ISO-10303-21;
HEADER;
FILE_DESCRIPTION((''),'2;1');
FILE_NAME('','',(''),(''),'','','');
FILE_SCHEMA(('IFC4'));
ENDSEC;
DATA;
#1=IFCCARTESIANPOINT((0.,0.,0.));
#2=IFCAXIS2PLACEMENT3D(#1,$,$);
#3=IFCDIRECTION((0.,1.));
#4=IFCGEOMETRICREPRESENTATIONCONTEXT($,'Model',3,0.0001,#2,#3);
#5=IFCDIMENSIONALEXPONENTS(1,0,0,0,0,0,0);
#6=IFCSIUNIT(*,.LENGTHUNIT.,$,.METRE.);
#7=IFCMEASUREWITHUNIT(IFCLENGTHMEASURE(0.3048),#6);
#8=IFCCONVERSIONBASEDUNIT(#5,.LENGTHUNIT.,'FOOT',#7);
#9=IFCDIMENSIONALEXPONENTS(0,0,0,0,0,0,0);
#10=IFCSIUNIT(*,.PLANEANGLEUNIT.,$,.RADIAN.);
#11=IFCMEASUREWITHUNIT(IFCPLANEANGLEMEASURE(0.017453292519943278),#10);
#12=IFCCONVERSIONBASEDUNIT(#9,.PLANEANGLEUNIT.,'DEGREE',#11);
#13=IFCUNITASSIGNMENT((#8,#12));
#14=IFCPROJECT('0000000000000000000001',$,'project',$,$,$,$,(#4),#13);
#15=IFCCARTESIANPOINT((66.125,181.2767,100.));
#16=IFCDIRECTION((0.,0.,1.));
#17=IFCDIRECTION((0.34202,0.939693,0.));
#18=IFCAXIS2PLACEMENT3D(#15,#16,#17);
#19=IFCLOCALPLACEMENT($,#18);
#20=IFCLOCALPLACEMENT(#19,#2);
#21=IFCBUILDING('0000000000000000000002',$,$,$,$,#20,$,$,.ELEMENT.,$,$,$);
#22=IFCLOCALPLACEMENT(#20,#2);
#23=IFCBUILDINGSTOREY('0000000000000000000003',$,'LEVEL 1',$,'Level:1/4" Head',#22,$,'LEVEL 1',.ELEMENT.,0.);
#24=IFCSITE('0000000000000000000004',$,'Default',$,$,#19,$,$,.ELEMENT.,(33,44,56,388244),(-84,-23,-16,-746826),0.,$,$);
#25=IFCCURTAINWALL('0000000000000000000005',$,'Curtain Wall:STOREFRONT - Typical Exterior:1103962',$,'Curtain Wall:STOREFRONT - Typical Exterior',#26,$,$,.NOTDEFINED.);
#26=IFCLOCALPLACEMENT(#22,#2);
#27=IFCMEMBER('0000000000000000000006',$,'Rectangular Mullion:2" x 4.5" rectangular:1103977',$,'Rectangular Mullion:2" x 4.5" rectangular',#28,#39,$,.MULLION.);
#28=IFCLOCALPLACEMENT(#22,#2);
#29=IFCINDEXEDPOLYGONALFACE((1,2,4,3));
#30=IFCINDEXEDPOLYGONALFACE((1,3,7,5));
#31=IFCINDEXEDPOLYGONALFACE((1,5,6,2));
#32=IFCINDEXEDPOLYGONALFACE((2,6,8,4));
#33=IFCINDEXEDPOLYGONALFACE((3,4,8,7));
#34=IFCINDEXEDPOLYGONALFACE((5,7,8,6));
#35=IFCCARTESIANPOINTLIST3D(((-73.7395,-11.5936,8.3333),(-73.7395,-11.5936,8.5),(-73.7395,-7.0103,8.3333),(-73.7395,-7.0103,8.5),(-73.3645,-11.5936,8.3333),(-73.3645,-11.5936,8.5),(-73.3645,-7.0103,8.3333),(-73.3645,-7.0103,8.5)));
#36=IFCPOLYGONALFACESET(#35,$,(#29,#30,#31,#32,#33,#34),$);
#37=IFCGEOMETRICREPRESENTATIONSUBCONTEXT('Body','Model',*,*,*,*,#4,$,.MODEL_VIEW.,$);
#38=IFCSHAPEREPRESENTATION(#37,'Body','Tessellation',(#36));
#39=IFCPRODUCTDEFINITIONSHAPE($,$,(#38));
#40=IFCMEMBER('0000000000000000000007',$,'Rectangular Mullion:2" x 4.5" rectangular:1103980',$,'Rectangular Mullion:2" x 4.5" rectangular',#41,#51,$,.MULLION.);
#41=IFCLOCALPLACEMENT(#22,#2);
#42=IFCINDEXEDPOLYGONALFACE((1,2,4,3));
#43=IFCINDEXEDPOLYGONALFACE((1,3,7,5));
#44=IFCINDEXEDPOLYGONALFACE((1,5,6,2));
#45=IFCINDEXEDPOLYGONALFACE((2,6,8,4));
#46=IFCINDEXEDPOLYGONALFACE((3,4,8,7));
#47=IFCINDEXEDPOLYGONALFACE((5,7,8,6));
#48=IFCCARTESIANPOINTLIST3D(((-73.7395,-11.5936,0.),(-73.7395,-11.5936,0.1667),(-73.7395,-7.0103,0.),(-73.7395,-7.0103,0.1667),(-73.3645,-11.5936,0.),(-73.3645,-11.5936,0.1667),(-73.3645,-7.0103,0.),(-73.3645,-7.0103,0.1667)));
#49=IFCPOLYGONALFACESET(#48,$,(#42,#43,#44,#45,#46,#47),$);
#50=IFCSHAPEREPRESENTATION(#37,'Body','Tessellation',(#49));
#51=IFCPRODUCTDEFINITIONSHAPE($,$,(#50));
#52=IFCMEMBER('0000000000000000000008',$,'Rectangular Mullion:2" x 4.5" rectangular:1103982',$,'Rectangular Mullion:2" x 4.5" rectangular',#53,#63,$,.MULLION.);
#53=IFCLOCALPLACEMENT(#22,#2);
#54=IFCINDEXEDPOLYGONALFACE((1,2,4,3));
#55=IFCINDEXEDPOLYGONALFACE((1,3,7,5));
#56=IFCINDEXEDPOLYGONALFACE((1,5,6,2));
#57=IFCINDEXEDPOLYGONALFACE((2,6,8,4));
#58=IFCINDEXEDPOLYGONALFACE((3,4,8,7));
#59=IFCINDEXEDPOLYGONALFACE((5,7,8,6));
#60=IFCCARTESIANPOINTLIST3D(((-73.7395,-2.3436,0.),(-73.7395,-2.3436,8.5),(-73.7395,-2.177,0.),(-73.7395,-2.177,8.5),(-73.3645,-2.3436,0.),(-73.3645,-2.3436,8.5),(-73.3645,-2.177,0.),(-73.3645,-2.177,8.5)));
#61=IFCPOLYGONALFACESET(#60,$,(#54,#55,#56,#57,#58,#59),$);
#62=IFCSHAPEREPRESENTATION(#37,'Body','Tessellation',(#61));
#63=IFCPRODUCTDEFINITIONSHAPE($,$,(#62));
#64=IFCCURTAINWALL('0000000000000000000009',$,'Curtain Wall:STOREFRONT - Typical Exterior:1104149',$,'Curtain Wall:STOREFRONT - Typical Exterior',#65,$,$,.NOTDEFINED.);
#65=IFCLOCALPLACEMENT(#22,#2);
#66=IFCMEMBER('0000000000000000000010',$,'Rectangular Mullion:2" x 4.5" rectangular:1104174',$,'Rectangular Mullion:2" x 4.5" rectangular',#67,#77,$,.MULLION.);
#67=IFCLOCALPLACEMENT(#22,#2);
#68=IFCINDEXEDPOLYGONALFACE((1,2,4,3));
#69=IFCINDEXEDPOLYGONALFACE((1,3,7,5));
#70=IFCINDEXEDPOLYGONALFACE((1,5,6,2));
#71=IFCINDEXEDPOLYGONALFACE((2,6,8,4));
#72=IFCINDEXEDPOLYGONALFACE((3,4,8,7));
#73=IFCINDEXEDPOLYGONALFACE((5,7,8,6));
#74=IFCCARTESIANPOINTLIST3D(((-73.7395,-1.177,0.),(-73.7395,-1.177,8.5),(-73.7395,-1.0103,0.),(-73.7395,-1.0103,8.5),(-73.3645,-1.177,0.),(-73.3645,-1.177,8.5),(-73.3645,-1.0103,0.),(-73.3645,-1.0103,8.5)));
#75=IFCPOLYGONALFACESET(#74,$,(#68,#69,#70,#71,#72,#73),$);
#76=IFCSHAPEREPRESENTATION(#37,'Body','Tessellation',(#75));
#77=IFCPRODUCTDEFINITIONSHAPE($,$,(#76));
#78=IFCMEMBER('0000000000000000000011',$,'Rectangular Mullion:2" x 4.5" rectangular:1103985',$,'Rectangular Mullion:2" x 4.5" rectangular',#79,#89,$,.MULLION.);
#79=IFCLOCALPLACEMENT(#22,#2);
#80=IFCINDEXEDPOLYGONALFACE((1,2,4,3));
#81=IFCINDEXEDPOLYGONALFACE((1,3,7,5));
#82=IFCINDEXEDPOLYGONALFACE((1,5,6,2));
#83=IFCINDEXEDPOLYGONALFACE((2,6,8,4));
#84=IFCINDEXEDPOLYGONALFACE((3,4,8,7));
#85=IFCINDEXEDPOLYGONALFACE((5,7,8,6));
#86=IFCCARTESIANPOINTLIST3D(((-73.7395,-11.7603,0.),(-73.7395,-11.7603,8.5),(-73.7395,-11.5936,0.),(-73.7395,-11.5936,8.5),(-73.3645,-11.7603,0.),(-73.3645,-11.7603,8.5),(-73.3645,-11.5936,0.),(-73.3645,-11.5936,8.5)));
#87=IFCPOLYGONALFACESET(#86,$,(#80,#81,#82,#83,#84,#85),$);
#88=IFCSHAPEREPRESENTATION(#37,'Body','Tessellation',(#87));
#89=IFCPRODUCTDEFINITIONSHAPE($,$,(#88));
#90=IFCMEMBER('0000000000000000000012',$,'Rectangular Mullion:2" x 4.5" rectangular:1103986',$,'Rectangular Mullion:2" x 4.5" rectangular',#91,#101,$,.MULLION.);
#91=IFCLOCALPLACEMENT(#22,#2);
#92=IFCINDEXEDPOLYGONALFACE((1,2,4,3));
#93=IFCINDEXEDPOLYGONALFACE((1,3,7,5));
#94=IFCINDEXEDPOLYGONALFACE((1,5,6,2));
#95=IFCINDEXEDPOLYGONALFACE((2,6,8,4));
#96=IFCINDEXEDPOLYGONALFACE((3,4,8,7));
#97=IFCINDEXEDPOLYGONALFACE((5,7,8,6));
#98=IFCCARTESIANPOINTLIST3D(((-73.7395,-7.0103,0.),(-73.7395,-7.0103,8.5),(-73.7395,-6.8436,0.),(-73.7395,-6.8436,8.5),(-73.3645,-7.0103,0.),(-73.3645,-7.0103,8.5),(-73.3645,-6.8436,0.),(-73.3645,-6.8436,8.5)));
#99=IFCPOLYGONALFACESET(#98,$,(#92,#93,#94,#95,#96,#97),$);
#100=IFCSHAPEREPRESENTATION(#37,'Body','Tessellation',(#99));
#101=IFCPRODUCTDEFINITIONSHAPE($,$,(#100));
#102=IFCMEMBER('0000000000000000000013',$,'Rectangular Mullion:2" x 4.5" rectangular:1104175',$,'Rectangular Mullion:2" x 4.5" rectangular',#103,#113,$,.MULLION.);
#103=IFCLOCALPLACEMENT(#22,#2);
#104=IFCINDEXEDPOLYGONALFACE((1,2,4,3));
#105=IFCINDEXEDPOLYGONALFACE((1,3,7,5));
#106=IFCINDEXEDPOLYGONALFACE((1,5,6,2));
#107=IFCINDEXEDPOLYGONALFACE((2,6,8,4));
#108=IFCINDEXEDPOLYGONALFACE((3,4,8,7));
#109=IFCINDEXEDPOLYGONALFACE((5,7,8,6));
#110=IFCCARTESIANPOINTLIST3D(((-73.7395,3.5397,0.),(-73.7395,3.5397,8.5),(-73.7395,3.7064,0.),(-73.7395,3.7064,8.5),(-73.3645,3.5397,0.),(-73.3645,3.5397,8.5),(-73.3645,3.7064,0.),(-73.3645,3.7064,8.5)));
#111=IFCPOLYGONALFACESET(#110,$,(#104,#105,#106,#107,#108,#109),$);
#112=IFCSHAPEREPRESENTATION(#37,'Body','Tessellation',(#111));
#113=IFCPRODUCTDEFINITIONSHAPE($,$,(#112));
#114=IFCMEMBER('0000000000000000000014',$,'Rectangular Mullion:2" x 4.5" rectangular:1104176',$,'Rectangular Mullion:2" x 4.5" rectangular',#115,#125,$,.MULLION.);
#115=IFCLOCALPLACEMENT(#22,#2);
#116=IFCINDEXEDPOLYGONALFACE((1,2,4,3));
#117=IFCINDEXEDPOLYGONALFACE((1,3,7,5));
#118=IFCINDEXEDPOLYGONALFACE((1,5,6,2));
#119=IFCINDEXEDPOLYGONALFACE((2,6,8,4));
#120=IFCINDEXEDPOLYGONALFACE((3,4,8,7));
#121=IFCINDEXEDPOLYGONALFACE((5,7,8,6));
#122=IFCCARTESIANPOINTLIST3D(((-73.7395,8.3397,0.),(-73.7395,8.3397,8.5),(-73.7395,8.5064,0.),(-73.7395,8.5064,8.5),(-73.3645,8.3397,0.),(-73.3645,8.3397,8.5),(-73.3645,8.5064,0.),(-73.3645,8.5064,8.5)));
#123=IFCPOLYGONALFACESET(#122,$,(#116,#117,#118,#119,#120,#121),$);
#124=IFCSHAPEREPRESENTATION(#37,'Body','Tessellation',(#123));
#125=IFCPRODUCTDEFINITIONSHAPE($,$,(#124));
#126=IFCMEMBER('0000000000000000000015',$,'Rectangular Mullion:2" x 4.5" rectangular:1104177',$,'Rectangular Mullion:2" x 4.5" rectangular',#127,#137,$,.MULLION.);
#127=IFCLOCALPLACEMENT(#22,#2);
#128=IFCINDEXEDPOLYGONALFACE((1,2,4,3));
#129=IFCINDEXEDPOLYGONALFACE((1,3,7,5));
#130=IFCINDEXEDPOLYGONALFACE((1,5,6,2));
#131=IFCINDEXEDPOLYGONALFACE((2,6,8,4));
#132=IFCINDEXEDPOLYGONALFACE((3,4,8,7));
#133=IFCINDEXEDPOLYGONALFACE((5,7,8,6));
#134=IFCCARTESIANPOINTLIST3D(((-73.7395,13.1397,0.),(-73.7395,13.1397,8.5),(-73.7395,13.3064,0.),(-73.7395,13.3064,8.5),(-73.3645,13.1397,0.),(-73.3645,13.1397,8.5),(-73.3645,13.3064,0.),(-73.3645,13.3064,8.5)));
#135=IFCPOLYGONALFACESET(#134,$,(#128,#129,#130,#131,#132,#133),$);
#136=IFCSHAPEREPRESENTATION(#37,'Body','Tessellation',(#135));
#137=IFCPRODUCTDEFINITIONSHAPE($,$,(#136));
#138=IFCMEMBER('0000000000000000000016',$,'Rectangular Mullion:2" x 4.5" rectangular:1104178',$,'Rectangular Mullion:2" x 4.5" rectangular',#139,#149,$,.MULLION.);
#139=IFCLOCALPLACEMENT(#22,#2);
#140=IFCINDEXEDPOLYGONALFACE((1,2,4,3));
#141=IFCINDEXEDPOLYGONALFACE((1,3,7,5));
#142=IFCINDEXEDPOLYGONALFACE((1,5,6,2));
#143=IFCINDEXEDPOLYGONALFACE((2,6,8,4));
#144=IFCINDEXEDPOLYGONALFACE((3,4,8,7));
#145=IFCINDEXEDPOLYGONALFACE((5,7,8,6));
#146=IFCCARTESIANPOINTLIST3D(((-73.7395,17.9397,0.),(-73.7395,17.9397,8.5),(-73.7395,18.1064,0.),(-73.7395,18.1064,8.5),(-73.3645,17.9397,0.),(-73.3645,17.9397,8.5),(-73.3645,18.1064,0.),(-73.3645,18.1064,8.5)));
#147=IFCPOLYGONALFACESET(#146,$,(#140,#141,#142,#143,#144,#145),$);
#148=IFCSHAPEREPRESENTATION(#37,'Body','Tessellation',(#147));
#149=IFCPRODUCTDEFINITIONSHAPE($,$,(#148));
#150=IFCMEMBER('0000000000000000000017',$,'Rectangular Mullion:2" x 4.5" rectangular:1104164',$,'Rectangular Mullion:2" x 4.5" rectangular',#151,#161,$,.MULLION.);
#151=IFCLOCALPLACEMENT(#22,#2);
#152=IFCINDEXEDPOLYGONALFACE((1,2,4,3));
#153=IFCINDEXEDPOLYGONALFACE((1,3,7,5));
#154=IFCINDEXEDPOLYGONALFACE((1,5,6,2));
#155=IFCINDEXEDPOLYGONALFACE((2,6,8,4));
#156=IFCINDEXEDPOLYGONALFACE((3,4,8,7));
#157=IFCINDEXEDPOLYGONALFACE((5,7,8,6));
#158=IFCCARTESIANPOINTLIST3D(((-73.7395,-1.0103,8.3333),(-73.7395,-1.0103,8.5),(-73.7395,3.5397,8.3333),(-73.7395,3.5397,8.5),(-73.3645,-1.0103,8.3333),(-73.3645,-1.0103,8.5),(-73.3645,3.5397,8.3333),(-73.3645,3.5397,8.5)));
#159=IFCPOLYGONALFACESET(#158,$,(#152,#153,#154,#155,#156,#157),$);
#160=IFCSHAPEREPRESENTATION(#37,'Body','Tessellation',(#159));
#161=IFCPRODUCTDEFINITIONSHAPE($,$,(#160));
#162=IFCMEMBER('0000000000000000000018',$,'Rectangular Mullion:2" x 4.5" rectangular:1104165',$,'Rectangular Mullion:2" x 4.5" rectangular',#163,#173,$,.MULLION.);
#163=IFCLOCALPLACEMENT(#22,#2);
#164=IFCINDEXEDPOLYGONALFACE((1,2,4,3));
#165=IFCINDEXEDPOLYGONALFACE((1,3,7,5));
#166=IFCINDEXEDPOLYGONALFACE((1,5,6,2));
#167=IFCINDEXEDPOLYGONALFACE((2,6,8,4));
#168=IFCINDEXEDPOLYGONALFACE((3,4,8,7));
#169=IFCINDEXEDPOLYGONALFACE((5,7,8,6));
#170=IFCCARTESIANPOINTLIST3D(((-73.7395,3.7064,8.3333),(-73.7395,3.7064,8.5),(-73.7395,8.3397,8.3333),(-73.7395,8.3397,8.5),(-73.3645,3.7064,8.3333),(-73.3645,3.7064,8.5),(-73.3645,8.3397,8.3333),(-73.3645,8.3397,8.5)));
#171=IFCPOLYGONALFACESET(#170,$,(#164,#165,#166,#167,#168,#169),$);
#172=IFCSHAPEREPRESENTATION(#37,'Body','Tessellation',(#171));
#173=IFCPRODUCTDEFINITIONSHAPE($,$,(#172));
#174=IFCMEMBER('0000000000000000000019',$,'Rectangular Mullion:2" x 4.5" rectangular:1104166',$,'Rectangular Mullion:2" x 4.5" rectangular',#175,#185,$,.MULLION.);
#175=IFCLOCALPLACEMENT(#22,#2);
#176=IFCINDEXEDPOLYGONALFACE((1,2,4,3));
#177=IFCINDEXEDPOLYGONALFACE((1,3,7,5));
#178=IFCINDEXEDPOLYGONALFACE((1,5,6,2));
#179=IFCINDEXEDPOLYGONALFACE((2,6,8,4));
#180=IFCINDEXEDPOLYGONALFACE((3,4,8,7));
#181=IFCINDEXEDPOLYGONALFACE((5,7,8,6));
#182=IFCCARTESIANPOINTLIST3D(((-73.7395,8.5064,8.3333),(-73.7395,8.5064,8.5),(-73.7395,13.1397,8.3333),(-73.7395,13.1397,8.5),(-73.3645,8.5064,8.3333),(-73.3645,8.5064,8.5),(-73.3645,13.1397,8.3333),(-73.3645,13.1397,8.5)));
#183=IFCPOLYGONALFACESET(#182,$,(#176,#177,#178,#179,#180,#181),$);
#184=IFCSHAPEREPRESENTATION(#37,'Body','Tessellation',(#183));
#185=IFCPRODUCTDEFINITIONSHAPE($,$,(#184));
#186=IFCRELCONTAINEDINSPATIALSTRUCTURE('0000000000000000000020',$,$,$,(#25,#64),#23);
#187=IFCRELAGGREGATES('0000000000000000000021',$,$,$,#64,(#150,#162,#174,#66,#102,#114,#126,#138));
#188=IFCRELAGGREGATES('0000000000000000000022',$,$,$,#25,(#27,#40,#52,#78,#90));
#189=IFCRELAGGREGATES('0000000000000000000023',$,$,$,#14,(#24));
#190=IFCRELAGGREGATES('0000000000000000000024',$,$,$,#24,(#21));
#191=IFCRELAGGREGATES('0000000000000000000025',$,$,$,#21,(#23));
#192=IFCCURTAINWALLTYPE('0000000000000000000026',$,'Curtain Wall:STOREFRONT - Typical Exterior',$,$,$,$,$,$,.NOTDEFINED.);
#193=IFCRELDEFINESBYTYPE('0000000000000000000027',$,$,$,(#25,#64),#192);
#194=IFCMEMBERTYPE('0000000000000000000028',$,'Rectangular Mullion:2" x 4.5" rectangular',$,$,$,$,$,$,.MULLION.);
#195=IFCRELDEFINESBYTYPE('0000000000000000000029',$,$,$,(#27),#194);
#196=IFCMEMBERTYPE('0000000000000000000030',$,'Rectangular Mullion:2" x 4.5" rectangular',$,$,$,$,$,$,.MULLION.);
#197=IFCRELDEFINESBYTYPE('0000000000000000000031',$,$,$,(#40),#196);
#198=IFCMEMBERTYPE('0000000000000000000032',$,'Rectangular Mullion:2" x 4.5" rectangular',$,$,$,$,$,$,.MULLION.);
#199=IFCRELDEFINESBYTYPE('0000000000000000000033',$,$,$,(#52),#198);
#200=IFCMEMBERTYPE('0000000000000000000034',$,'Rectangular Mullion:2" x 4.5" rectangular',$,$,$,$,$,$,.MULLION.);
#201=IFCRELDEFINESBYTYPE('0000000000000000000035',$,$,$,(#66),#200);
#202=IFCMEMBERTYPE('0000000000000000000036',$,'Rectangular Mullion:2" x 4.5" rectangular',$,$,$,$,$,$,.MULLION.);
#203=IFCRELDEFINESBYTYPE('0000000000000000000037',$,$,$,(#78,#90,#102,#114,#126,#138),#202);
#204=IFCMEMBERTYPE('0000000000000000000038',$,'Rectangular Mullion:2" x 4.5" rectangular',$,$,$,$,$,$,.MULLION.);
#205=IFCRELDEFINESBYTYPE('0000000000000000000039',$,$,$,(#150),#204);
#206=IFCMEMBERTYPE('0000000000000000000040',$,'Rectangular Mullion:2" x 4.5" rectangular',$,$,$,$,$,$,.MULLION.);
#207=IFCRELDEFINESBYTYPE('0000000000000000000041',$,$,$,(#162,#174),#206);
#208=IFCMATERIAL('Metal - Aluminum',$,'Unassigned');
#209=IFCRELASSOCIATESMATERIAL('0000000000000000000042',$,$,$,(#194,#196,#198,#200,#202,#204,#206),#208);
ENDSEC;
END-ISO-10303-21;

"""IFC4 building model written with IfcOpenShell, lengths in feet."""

from ifc_helpers import new_model, entity, si_unit, converted_unit, direction, frame, origin, origin_2d_with_axis, place, context, subcontext, project, spatial, rectangle, extrude, source, transform, mapped, material, material_profile, profile_set, type_object, type_shapes, element, aggregate, save


model = new_model("IFC4")

# Units and contexts
model_context = context("Model", 3, precision=0.0001, world=origin(), true_north=direction((0.0, 1.0)))
body_context = subcontext(model_context, "Body", "Model", "MODEL_VIEW")
ifc_project = project(units=[converted_unit("LENGTHUNIT", "FOOT", entity("IfcLengthMeasure", 0.3048), si_unit("LENGTHUNIT", "METRE"), dimensions=[1, 0, 0, 0, 0, 0, 0]), converted_unit("PLANEANGLEUNIT", "DEGREE", entity("IfcPlaneAngleMeasure", 0.017453292519943278), si_unit("PLANEANGLEUNIT", "RADIAN"), dimensions=[0, 0, 0, 0, 0, 0, 0])], contexts=[model_context])

# Site, building, storey
site_placement = place(None, frame((66.125, 181.2767, 100.0), z_axis=(0.0, 0.0, 1.0), x_axis=(0.34202, 0.939693, 0.0)))
site = spatial("IfcSite", under=ifc_project, at=site_placement, Name="Default", CompositionType="ELEMENT", RefLatitude=(33, 44, 56, 388244), RefLongitude=(-84, -23, -16, -746826), RefElevation=0.0)
building_placement = place(site_placement, origin())
building = spatial("IfcBuilding", under=site, at=building_placement, CompositionType="ELEMENT")
storey_placement = place(building_placement, origin())
storey = spatial("IfcBuildingStorey", under=building, at=storey_placement, Name="LEVEL 1", ObjectType="Level:1/4\" Head", LongName="LEVEL 1", CompositionType="ELEMENT", Elevation=0.0)

# Curtain wall, members
curtain_wall_type = type_object("IfcCurtainWallType", Name="Curtain Wall:STOREFRONT - Typical Exterior", PredefinedType="NOTDEFINED")
curtain_wall_1_placement = place(storey_placement, origin())
curtain_wall_1 = element("IfcCurtainWall", 1, at=curtain_wall_1_placement, inside=storey, type_object=curtain_wall_type, Name="Curtain Wall:STOREFRONT - Typical Exterior:1103962", ObjectType="Curtain Wall:STOREFRONT - Typical Exterior", PredefinedType="NOTDEFINED")
ifc_material_1 = material(Name="Metal - Aluminum", Category="Unassigned")
ifc_material_profile = material_profile(ifc_material_1, rectangle(XDim=0.1667, YDim=0.375, at=origin_2d_with_axis()), Name="2\" x 4.5\" rectangular")
ifc_profile_set = profile_set([ifc_material_profile], Name="2\" x 4.5\" rectangular")
member_type_1 = type_object("IfcMemberType", Name="Rectangular Mullion:2\" x 4.5\" rectangular", PredefinedType="MULLION", material=ifc_profile_set)
shared_shape_1 = source(origin(), body_context, "Body", "SweptSolid", [
    extrude(rectangle(XDim=0.1667, YDim=0.375, at=origin_2d_with_axis()), frame((-0.0833, 0.0, -4.5833), z_axis=(0.0, 0.0, 1.0), x_axis=(-1.0, 0.0, 0.0)), (0.0, 0.0, 1.0), 4.5833),
])
type_shapes(member_type_1, [shared_shape_1])
member_1_placement = place(curtain_wall_1_placement, frame((-73.552, -7.0103, 8.5), z_axis=(0.0, 1.0, 0.0), x_axis=(0.0, 0.0, 1.0)))
member_1 = element("IfcMember", 2, at=member_1_placement, type_object=member_type_1, Name="Rectangular Mullion:2\" x 4.5\" rectangular:1103977", ObjectType="Rectangular Mullion:2\" x 4.5\" rectangular", PredefinedType="MULLION", context=body_context, shape_type="MappedRepresentation", body=[
    mapped(shared_shape_1, transform((0.0, 0.0, 0.0), scale=1.0)),
])
member_type_2 = type_object("IfcMemberType", Name="Rectangular Mullion:2\" x 4.5\" rectangular", PredefinedType="MULLION", material=ifc_profile_set)
shared_shape_2 = source(origin(), body_context, "Body", "SweptSolid", [
    extrude(rectangle(XDim=0.1667, YDim=0.375, at=origin_2d_with_axis()), frame((-0.0833, 0.0, -4.5833), z_axis=(0.0, 0.0, 1.0), x_axis=(-1.0, 0.0, 0.0)), (0.0, 0.0, 1.0), 4.5833),
])
type_shapes(member_type_2, [shared_shape_2])
member_2_placement = place(curtain_wall_1_placement, frame((-73.552, -11.5936, 0.0), z_axis=(0.0, -1.0, 0.0), x_axis=(0.0, 0.0, -1.0)))
member_2 = element("IfcMember", 3, at=member_2_placement, type_object=member_type_2, Name="Rectangular Mullion:2\" x 4.5\" rectangular:1103980", ObjectType="Rectangular Mullion:2\" x 4.5\" rectangular", PredefinedType="MULLION", context=body_context, shape_type="MappedRepresentation", body=[
    mapped(shared_shape_2, transform((0.0, 0.0, 0.0), scale=1.0)),
])
member_type_3 = type_object("IfcMemberType", Name="Rectangular Mullion:2\" x 4.5\" rectangular", PredefinedType="MULLION", material=ifc_profile_set)
shared_shape_3 = source(origin(), body_context, "Body", "SweptSolid", [
    extrude(rectangle(XDim=0.1667, YDim=0.375, at=origin_2d_with_axis()), frame((-0.0833, 0.0, -8.5), z_axis=(0.0, 0.0, 1.0), x_axis=(-1.0, 0.0, 0.0)), (0.0, 0.0, 1.0), 8.5),
])
type_shapes(member_type_3, [shared_shape_3])
member_3_placement = place(curtain_wall_1_placement, frame((-73.552, -2.177, 0.0), z_axis=(0.0, 0.0, -1.0), x_axis=(0.0, 1.0, 0.0)))
member_3 = element("IfcMember", 4, at=member_3_placement, type_object=member_type_3, Name="Rectangular Mullion:2\" x 4.5\" rectangular:1103982", ObjectType="Rectangular Mullion:2\" x 4.5\" rectangular", PredefinedType="MULLION", context=body_context, shape_type="MappedRepresentation", body=[
    mapped(shared_shape_3, transform((0.0, 0.0, 0.0), scale=1.0)),
])

# Curtain wall, member
curtain_wall_2_placement = place(storey_placement, origin())
curtain_wall_2 = element("IfcCurtainWall", 5, at=curtain_wall_2_placement, inside=storey, type_object=curtain_wall_type, Name="Curtain Wall:STOREFRONT - Typical Exterior:1104149", ObjectType="Curtain Wall:STOREFRONT - Typical Exterior", PredefinedType="NOTDEFINED")
member_type_4 = type_object("IfcMemberType", Name="Rectangular Mullion:2\" x 4.5\" rectangular", PredefinedType="MULLION", material=ifc_profile_set)
shared_shape_4 = source(origin(), body_context, "Body", "SweptSolid", [
    extrude(rectangle(XDim=0.1667, YDim=0.375, at=origin_2d_with_axis()), frame((-0.0833, 0.0, -8.5), z_axis=(0.0, 0.0, 1.0), x_axis=(-1.0, 0.0, 0.0)), (0.0, 0.0, 1.0), 8.5),
])
type_shapes(member_type_4, [shared_shape_4])
member_4_placement = place(curtain_wall_2_placement, frame((-73.552, -1.177, 8.5), z_axis=(0.0, 0.0, 1.0), x_axis=(0.0, -1.0, 0.0)))
member_4 = element("IfcMember", 6, at=member_4_placement, type_object=member_type_4, Name="Rectangular Mullion:2\" x 4.5\" rectangular:1104174", ObjectType="Rectangular Mullion:2\" x 4.5\" rectangular", PredefinedType="MULLION", context=body_context, shape_type="MappedRepresentation", body=[
    mapped(shared_shape_4, transform((0.0, 0.0, 0.0), scale=1.0)),
])

# Members
member_type_5 = type_object("IfcMemberType", Name="Rectangular Mullion:2\" x 4.5\" rectangular", PredefinedType="MULLION", material=ifc_profile_set)
shared_shape_5 = source(origin(), body_context, "Body", "SweptSolid", [
    extrude(rectangle(XDim=0.1667, YDim=0.375, at=origin_2d_with_axis()), frame((0.0, 0.0, -8.5), z_axis=(0.0, 0.0, 1.0), x_axis=(-1.0, 0.0, 0.0)), (0.0, 0.0, 1.0), 8.5),
])
type_shapes(member_type_5, [shared_shape_5])
member_5_placement = place(curtain_wall_1_placement, frame((-73.552, -11.677, 0.0), z_axis=(0.0, 0.0, -1.0), x_axis=(0.0, 1.0, 0.0)))
member_5 = element("IfcMember", 7, at=member_5_placement, type_object=member_type_5, Name="Rectangular Mullion:2\" x 4.5\" rectangular:1103985", ObjectType="Rectangular Mullion:2\" x 4.5\" rectangular", PredefinedType="MULLION", context=body_context, shape_type="MappedRepresentation", body=[
    mapped(shared_shape_5, transform((0.0, 0.0, 0.0), scale=1.0)),
])
member_6_placement = place(curtain_wall_1_placement, frame((-73.552, -6.927, 0.0), z_axis=(0.0, 0.0, -1.0), x_axis=(0.0, 1.0, 0.0)))
member_6 = element("IfcMember", 8, at=member_6_placement, type_object=member_type_5, Name="Rectangular Mullion:2\" x 4.5\" rectangular:1103986", ObjectType="Rectangular Mullion:2\" x 4.5\" rectangular", PredefinedType="MULLION", context=body_context, shape_type="MappedRepresentation", body=[
    mapped(shared_shape_5, transform((0.0, 0.0, 0.0), scale=1.0)),
])
member_7_placement = place(curtain_wall_2_placement, frame((-73.552, 3.623, 0.0), z_axis=(0.0, 0.0, -1.0), x_axis=(0.0, 1.0, 0.0)))
member_7 = element("IfcMember", 9, at=member_7_placement, type_object=member_type_5, Name="Rectangular Mullion:2\" x 4.5\" rectangular:1104175", ObjectType="Rectangular Mullion:2\" x 4.5\" rectangular", PredefinedType="MULLION", context=body_context, shape_type="MappedRepresentation", body=[
    mapped(shared_shape_5, transform((0.0, 0.0, 0.0), scale=1.0)),
])
member_8_placement = place(curtain_wall_2_placement, frame((-73.552, 8.423, 0.0), z_axis=(0.0, 0.0, -1.0), x_axis=(0.0, 1.0, 0.0)))
member_8 = element("IfcMember", 10, at=member_8_placement, type_object=member_type_5, Name="Rectangular Mullion:2\" x 4.5\" rectangular:1104176", ObjectType="Rectangular Mullion:2\" x 4.5\" rectangular", PredefinedType="MULLION", context=body_context, shape_type="MappedRepresentation", body=[
    mapped(shared_shape_5, transform((0.0, 0.0, 0.0), scale=1.0)),
])
member_9_placement = place(curtain_wall_2_placement, frame((-73.552, 13.223, 0.0), z_axis=(0.0, 0.0, -1.0), x_axis=(0.0, 1.0, 0.0)))
member_9 = element("IfcMember", 11, at=member_9_placement, type_object=member_type_5, Name="Rectangular Mullion:2\" x 4.5\" rectangular:1104177", ObjectType="Rectangular Mullion:2\" x 4.5\" rectangular", PredefinedType="MULLION", context=body_context, shape_type="MappedRepresentation", body=[
    mapped(shared_shape_5, transform((0.0, 0.0, 0.0), scale=1.0)),
])
member_10_placement = place(curtain_wall_2_placement, frame((-73.552, 18.023, 0.0), z_axis=(0.0, 0.0, -1.0), x_axis=(0.0, 1.0, 0.0)))
member_10 = element("IfcMember", 12, at=member_10_placement, type_object=member_type_5, Name="Rectangular Mullion:2\" x 4.5\" rectangular:1104178", ObjectType="Rectangular Mullion:2\" x 4.5\" rectangular", PredefinedType="MULLION", context=body_context, shape_type="MappedRepresentation", body=[
    mapped(shared_shape_5, transform((0.0, 0.0, 0.0), scale=1.0)),
])
member_type_6 = type_object("IfcMemberType", Name="Rectangular Mullion:2\" x 4.5\" rectangular", PredefinedType="MULLION", material=ifc_profile_set)
shared_shape_6 = source(origin(), body_context, "Body", "SweptSolid", [
    extrude(rectangle(XDim=0.1667, YDim=0.375, at=origin_2d_with_axis()), frame((-0.0833, 0.0, -4.55), z_axis=(0.0, 0.0, 1.0), x_axis=(-1.0, 0.0, 0.0)), (0.0, 0.0, 1.0), 4.55),
])
type_shapes(member_type_6, [shared_shape_6])
member_11_placement = place(curtain_wall_2_placement, frame((-73.552, 3.5397, 8.5), z_axis=(0.0, 1.0, 0.0), x_axis=(0.0, 0.0, 1.0)))
member_11 = element("IfcMember", 13, at=member_11_placement, type_object=member_type_6, Name="Rectangular Mullion:2\" x 4.5\" rectangular:1104164", ObjectType="Rectangular Mullion:2\" x 4.5\" rectangular", PredefinedType="MULLION", context=body_context, shape_type="MappedRepresentation", body=[
    mapped(shared_shape_6, transform((0.0, 0.0, 0.0), scale=1.0)),
])
member_type_7 = type_object("IfcMemberType", Name="Rectangular Mullion:2\" x 4.5\" rectangular", PredefinedType="MULLION", material=ifc_profile_set)
shared_shape_7 = source(origin(), body_context, "Body", "SweptSolid", [
    extrude(rectangle(XDim=0.1667, YDim=0.375, at=origin_2d_with_axis()), frame((-0.0833, 0.0, -4.6333), z_axis=(0.0, 0.0, 1.0), x_axis=(-1.0, 0.0, 0.0)), (0.0, 0.0, 1.0), 4.6333),
])
type_shapes(member_type_7, [shared_shape_7])
member_12_placement = place(curtain_wall_2_placement, frame((-73.552, 8.3397, 8.5), z_axis=(0.0, 1.0, 0.0), x_axis=(0.0, 0.0, 1.0)))
member_12 = element("IfcMember", 14, at=member_12_placement, type_object=member_type_7, Name="Rectangular Mullion:2\" x 4.5\" rectangular:1104165", ObjectType="Rectangular Mullion:2\" x 4.5\" rectangular", PredefinedType="MULLION", context=body_context, shape_type="MappedRepresentation", body=[
    mapped(shared_shape_7, transform((0.0, 0.0, 0.0), scale=1.0)),
])
member_13_placement = place(curtain_wall_2_placement, frame((-73.552, 13.1397, 8.5), z_axis=(0.0, 1.0, 0.0), x_axis=(0.0, 0.0, 1.0)))
member_13 = element("IfcMember", 15, at=member_13_placement, type_object=member_type_7, Name="Rectangular Mullion:2\" x 4.5\" rectangular:1104166", ObjectType="Rectangular Mullion:2\" x 4.5\" rectangular", PredefinedType="MULLION", context=body_context, shape_type="MappedRepresentation", body=[
    mapped(shared_shape_7, transform((0.0, 0.0, 0.0), scale=1.0)),
])

aggregate(curtain_wall_2, [member_11, member_12, member_13, member_4, member_7, member_8, member_9, member_10])
aggregate(curtain_wall_1, [member_1, member_2, member_3, member_5, member_6])

save(model, "model.ifc")
